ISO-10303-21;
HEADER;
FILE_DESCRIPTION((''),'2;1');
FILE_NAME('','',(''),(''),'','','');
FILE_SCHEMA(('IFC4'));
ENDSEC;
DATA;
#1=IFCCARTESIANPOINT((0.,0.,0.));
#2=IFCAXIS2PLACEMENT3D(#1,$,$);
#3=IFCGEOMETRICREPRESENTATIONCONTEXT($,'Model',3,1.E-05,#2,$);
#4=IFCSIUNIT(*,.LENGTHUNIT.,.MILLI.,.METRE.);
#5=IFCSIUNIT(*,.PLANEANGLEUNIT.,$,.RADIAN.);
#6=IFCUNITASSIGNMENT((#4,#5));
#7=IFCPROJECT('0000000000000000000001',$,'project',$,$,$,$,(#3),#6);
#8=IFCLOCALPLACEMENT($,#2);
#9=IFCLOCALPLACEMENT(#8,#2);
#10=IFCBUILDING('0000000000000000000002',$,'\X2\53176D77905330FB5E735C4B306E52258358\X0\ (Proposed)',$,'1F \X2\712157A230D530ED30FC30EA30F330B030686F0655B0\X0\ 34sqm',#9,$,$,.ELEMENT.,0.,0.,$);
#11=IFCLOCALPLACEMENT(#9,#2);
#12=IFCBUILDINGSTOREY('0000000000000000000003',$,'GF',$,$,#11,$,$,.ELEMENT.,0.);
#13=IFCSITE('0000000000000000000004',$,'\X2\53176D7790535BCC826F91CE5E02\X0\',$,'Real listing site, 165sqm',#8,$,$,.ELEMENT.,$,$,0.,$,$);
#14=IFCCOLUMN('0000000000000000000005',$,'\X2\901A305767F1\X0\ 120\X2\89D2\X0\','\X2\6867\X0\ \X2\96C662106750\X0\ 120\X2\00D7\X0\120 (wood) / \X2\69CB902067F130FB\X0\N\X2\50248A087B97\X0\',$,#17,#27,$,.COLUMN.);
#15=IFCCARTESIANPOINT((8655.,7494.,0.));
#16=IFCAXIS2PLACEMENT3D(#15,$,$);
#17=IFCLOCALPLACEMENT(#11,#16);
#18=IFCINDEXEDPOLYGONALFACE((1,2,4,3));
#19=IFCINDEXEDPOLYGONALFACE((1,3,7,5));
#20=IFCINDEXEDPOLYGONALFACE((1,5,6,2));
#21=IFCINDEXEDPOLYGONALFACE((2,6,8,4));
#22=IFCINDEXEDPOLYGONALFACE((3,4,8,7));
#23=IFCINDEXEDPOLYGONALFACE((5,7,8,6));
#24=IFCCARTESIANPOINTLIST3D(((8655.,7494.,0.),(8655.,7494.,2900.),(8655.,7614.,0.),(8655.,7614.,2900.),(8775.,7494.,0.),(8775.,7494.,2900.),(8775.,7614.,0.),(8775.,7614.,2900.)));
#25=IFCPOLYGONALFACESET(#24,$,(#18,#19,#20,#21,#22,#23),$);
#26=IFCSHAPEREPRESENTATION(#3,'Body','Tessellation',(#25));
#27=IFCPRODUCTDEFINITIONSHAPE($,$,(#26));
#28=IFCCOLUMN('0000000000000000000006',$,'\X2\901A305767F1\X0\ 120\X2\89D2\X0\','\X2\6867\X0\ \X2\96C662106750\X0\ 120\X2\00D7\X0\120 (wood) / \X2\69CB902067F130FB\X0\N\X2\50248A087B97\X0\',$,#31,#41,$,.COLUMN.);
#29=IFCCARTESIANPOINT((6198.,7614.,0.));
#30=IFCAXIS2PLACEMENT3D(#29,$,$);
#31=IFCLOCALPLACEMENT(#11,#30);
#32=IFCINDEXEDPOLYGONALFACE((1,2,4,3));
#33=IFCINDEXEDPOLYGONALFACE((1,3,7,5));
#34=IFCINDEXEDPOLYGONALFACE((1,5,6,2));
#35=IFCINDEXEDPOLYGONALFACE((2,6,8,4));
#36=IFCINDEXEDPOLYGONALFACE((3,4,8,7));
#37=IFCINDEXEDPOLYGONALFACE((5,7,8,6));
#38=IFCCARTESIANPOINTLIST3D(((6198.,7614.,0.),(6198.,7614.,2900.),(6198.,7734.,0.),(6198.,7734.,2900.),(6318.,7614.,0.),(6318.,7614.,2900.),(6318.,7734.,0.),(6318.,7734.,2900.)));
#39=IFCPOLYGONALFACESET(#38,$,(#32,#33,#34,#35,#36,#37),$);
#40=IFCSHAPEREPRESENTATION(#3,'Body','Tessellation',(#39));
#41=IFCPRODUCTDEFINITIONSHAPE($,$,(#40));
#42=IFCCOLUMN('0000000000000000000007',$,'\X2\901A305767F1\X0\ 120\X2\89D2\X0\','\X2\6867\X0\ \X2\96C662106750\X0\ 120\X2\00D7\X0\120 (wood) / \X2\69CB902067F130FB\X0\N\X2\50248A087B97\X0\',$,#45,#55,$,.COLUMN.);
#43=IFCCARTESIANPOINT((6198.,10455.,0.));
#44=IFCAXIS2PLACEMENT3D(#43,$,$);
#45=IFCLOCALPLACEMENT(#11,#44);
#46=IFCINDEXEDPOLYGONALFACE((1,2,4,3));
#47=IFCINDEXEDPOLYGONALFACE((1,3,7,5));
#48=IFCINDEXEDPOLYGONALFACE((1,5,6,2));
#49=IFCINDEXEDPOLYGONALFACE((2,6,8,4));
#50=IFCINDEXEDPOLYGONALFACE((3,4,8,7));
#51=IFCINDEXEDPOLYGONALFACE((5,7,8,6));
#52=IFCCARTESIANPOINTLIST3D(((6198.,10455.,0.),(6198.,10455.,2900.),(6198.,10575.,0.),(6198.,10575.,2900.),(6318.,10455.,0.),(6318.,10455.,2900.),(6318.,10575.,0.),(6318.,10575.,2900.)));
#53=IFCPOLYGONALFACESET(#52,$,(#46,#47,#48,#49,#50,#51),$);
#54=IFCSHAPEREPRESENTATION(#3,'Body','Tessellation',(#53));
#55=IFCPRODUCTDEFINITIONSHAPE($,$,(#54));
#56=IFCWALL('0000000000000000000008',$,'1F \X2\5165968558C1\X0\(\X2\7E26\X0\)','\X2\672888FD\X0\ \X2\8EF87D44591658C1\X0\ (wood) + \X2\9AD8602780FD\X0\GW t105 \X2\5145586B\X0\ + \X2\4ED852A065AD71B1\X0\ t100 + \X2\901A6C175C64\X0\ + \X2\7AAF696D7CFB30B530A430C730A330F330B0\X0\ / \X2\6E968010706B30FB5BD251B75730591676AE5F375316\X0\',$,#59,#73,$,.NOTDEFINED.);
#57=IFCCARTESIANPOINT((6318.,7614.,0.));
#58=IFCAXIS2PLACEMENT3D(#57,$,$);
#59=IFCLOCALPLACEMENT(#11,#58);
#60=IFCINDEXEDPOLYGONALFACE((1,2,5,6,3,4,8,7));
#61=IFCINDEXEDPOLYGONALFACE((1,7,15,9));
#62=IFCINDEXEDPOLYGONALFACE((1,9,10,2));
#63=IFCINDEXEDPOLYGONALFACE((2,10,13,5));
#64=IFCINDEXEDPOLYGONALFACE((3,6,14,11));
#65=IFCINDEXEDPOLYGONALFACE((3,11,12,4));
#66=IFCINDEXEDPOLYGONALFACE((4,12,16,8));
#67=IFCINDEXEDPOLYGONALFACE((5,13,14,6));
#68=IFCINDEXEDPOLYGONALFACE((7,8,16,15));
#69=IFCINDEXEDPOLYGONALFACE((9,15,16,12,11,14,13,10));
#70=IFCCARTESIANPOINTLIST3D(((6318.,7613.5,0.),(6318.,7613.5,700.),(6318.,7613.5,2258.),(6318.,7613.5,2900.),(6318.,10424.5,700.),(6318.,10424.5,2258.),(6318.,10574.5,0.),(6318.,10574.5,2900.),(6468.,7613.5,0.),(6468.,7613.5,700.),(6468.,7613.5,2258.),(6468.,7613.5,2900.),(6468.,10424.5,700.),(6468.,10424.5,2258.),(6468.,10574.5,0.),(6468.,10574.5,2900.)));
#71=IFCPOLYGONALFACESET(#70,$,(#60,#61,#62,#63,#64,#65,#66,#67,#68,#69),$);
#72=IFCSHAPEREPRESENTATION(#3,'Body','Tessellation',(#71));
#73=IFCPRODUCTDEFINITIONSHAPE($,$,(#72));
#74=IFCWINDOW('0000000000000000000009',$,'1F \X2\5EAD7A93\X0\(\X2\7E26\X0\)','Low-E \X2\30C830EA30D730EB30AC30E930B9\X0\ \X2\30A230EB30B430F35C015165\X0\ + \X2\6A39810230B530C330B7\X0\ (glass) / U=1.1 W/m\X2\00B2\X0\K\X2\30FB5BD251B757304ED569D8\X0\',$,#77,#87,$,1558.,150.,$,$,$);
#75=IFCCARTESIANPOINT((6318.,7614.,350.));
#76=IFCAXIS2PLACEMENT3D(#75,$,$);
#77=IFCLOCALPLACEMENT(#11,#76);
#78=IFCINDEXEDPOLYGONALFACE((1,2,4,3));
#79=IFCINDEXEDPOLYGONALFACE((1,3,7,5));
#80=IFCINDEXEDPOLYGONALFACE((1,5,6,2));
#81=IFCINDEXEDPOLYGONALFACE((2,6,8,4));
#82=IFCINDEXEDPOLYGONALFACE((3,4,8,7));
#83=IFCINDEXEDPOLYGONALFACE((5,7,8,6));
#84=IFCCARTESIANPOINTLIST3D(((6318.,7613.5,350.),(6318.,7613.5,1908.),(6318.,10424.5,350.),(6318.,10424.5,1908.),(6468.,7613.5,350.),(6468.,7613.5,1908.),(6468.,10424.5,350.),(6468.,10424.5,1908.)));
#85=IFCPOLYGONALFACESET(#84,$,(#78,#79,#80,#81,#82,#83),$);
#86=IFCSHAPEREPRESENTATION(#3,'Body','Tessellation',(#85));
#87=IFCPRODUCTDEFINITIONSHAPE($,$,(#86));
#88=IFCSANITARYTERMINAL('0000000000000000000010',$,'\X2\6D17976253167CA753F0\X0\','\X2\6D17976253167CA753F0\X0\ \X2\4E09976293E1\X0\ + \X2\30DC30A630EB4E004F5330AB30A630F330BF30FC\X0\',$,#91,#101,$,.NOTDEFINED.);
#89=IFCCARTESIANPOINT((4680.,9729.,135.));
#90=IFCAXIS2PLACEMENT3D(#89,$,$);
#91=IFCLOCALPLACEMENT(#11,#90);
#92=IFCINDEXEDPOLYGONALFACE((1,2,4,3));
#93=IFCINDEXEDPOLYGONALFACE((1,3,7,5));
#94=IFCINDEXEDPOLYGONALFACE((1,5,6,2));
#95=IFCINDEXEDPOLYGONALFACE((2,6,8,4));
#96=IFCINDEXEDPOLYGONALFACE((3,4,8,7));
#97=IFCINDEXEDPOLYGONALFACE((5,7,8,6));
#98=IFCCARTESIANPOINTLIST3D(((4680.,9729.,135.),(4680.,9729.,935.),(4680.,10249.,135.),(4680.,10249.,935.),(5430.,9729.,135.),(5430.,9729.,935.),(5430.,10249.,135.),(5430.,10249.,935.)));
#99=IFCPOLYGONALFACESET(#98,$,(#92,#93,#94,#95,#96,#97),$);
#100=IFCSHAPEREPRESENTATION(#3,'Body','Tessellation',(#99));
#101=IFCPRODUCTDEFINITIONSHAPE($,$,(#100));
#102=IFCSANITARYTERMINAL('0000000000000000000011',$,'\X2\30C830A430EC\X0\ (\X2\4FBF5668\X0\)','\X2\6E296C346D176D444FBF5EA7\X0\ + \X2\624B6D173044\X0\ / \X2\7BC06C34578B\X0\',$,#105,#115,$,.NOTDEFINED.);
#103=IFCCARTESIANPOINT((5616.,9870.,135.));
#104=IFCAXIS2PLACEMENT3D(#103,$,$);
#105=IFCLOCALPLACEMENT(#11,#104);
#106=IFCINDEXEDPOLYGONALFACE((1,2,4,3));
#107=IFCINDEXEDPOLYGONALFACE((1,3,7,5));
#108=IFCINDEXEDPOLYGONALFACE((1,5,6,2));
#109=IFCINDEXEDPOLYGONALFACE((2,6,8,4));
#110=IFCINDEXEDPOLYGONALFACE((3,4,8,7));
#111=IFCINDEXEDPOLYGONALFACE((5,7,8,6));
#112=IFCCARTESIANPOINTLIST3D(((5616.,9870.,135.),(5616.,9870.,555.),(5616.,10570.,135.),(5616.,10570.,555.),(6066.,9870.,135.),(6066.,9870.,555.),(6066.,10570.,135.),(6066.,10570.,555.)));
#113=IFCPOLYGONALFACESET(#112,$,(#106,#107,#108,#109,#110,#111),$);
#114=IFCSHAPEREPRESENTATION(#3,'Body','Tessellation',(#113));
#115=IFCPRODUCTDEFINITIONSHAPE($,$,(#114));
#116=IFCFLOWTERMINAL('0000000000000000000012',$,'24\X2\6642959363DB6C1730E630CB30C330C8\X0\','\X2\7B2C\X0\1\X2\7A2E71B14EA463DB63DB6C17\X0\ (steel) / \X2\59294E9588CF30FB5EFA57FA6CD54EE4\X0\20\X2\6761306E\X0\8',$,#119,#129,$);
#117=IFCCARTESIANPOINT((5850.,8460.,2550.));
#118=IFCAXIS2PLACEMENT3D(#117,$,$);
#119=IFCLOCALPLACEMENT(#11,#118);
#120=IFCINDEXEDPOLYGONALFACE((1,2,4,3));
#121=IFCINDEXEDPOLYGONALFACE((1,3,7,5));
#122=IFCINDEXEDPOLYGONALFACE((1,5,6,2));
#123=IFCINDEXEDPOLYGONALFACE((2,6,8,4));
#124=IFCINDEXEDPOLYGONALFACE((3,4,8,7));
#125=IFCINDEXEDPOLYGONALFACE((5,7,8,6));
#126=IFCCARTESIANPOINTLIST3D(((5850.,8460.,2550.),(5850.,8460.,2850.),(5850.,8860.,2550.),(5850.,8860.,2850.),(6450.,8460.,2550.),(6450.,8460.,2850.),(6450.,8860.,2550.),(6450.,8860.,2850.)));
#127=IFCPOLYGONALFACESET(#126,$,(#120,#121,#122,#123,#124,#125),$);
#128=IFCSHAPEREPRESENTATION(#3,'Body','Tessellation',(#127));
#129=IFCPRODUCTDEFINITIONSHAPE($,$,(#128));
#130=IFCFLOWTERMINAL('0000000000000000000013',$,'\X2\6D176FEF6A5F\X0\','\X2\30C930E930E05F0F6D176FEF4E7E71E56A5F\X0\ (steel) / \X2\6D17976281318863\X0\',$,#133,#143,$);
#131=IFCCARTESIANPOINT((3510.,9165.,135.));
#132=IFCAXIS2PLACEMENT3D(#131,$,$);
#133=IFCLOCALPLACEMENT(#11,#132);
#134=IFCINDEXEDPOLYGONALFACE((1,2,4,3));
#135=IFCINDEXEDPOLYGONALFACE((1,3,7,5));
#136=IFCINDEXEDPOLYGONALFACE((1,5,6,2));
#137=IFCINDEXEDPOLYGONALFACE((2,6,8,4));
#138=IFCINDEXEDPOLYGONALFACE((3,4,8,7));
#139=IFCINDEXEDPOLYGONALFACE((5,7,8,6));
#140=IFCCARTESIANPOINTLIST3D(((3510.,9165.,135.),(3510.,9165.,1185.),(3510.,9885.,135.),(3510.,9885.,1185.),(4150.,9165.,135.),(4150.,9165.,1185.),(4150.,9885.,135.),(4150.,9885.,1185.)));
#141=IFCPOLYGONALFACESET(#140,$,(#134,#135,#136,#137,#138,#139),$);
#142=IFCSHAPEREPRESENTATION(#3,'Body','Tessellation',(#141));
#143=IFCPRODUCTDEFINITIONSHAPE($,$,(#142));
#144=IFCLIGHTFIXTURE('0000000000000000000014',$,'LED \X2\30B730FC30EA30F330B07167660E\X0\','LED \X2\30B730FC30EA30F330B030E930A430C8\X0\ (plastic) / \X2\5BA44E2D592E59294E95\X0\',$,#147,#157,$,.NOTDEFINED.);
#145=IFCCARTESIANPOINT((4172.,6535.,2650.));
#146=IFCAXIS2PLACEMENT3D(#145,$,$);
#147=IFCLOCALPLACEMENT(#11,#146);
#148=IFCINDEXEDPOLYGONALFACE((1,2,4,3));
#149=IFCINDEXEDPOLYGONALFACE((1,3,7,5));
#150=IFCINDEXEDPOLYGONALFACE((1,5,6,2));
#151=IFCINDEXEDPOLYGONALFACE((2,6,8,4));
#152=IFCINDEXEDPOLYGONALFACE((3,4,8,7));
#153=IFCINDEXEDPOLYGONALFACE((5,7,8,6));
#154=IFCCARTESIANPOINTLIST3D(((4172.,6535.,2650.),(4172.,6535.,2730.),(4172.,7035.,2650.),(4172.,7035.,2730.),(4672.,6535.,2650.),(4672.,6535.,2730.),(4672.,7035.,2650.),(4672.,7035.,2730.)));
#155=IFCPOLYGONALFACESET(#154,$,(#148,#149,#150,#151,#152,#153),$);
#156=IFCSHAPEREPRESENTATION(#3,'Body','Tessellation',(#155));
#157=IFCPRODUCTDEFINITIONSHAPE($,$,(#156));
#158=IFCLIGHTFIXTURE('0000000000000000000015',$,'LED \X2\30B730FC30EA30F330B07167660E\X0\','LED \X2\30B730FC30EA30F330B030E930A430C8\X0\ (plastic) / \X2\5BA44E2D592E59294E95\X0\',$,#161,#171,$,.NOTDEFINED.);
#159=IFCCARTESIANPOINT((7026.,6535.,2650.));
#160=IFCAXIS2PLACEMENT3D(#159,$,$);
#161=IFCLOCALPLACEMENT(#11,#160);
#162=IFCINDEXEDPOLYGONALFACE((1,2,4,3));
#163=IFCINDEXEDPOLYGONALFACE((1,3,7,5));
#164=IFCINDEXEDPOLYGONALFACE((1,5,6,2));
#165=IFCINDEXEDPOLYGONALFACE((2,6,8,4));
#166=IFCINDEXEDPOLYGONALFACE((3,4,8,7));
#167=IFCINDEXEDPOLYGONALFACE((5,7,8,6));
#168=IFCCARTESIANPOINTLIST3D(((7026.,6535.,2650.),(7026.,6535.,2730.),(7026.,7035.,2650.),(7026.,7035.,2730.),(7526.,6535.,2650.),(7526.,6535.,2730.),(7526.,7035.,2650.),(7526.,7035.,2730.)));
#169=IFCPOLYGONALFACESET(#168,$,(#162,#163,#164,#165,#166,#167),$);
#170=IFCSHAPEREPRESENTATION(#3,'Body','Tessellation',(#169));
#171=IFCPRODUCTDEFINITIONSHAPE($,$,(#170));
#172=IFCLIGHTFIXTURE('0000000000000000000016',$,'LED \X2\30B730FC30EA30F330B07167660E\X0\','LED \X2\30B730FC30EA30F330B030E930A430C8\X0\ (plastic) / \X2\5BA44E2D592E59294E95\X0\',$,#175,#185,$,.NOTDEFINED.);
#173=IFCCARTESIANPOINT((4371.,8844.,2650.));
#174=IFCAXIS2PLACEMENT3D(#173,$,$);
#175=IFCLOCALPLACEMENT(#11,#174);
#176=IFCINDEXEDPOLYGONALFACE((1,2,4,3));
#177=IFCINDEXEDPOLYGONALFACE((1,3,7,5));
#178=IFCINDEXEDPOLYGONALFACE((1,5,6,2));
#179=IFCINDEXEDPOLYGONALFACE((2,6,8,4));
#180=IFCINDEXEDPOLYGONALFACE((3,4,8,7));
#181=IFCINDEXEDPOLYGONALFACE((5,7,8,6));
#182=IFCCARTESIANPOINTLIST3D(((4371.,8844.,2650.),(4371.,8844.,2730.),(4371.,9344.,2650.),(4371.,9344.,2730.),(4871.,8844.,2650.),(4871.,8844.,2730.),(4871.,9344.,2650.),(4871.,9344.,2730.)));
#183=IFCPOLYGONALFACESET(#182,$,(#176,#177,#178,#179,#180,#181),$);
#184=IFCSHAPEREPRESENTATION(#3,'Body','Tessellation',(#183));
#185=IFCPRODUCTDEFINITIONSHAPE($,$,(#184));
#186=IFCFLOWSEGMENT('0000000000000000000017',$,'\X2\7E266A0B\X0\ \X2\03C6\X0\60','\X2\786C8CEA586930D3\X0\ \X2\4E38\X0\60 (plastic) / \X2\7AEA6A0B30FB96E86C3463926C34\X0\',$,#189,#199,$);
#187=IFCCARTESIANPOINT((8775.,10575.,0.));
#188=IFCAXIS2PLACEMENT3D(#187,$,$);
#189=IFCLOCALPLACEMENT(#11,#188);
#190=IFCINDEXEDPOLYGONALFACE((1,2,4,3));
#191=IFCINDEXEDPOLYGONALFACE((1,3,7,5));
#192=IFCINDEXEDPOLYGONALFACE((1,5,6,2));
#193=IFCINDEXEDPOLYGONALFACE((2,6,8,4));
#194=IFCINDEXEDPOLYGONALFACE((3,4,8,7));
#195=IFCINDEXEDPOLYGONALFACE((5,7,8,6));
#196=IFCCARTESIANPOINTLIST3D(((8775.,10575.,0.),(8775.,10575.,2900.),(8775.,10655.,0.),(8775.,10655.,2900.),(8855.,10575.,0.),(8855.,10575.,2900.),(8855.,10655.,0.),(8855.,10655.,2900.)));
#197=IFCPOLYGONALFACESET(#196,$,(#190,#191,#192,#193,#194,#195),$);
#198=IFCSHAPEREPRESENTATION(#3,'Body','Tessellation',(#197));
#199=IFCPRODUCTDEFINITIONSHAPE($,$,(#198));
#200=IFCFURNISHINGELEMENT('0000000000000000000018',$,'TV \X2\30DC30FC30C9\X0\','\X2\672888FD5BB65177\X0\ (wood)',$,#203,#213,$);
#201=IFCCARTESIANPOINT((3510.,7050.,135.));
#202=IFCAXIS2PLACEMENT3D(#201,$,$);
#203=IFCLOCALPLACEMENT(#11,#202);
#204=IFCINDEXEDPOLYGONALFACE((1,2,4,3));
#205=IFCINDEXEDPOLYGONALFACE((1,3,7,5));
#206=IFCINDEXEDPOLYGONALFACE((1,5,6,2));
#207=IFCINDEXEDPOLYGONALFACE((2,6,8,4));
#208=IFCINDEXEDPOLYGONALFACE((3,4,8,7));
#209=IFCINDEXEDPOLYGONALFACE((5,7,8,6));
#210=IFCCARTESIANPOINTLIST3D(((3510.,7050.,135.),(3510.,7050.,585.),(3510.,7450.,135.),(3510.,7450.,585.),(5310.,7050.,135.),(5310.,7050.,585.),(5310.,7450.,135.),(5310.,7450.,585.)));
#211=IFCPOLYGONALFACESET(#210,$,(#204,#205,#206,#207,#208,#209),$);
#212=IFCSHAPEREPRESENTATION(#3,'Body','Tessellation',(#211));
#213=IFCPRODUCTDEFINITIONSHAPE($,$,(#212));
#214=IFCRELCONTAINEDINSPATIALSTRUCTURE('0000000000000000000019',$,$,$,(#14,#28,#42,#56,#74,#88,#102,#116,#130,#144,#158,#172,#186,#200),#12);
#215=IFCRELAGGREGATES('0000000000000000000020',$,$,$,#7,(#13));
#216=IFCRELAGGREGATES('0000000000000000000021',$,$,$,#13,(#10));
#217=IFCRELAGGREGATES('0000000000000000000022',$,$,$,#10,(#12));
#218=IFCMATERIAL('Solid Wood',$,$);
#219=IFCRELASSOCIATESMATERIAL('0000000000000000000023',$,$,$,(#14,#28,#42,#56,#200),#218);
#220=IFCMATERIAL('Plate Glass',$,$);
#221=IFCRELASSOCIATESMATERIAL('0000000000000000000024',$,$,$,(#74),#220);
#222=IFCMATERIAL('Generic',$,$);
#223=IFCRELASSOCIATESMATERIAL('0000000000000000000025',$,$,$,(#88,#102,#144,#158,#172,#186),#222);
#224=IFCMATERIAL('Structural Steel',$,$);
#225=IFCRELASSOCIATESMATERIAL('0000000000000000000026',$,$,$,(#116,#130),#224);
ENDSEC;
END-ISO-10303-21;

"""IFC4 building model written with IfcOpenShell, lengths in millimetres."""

from ifc_helpers import new_model, si_unit, frame, frame_2d, origin, place, context, project, spatial, rectangle, extrude, material, element, fill, save


model = new_model("IFC4")

# Units and contexts
model_context = context("Model", 3, precision=1e-05, world=origin())
ifc_project = project(units=[si_unit("LENGTHUNIT", "METRE", prefix="MILLI"), si_unit("PLANEANGLEUNIT", "RADIAN")], contexts=[model_context])

# Site, building, storey
site_placement = place(None, origin())
site = spatial("IfcSite", under=ifc_project, at=site_placement, Name="北海道富良野市", ObjectType="Real listing site, 165sqm", CompositionType="ELEMENT", RefElevation=0.0)
building_placement = place(site_placement, origin())
building = spatial("IfcBuilding", under=site, at=building_placement, Name="北海道・平屋の別荘 (Proposed)", ObjectType="1F 無垢フローリングと漆喰 34sqm", CompositionType="ELEMENT", ElevationOfRefHeight=0.0, ElevationOfTerrain=0.0)
storey_placement = place(building_placement, origin())
storey = spatial("IfcBuildingStorey", under=building, at=storey_placement, Name="GF", CompositionType="ELEMENT", Elevation=0.0)

# Columns
ifc_material_1 = material(Name="Solid Wood")
column_1_placement = place(storey_placement, frame((8655.0, 7494.0, 0.0)))
element("IfcColumn", 1, at=column_1_placement, inside=storey, material=ifc_material_1, Name="通し柱 120角", Description="桧 集成材 120×120 (wood) / 構造柱・N値計算", PredefinedType="COLUMN", context=model_context, shape_type="SweptSolid", body=[
    extrude(rectangle(XDim=120.0, YDim=120.0, at=frame_2d((60.0, 60.0))), frame((8655.0, 7494.0, 0.0)), (0.0, 0.0, 1.0), 2900.0),
])
column_2_placement = place(storey_placement, frame((6198.0, 7614.0, 0.0)))
element("IfcColumn", 2, at=column_2_placement, inside=storey, material=ifc_material_1, Name="通し柱 120角", Description="桧 集成材 120×120 (wood) / 構造柱・N値計算", PredefinedType="COLUMN", context=model_context, shape_type="SweptSolid", body=[
    extrude(rectangle(XDim=120.0, YDim=120.0, at=frame_2d((60.0, 60.0))), frame((6198.0, 7614.0, 0.0)), (0.0, 0.0, 1.0), 2900.0),
])
column_3_placement = place(storey_placement, frame((6198.0, 10455.0, 0.0)))
element("IfcColumn", 3, at=column_3_placement, inside=storey, material=ifc_material_1, Name="通し柱 120角", Description="桧 集成材 120×120 (wood) / 構造柱・N値計算", PredefinedType="COLUMN", context=model_context, shape_type="SweptSolid", body=[
    extrude(rectangle(XDim=120.0, YDim=120.0, at=frame_2d((60.0, 60.0))), frame((6198.0, 10455.0, 0.0)), (0.0, 0.0, 1.0), 2900.0),
])

# Wall, opening, window
wall_1_placement = place(storey_placement, frame((6318.0, 7614.0, 0.0)))
wall_1 = element("IfcWall", 4, at=wall_1_placement, inside=storey, material=ifc_material_1, Name="1F 入隅壁(縦)", Description="木製 軸組外壁 (wood) + 高性能GW t105 充填 + 付加断熱 t100 + 通気層 + 窯業系サイディング / 準耐火・寒冷地外皮強化", PredefinedType="NOTDEFINED", context=model_context, shape_type="SweptSolid", body=[
    extrude(rectangle(XDim=150.0, YDim=2961.0, at=frame_2d((75.0, 1480.0))), frame((6318.0, 7614.0, 0.0)), (0.0, 0.0, 1.0), 2900.0),
])
opening_placement = place(storey_placement, frame((6318.0, 7614.0, 350.0)))
opening = element("IfcOpeningElement", 5, at=opening_placement, cuts=wall_1, PredefinedType="NOTDEFINED", context=model_context, shape_type="SweptSolid", body=[
    extrude(rectangle(XDim=150.0, YDim=2811.0, at=frame_2d((75.0, 1405.0))), frame((6318.0, 7614.0, 350.0)), (0.0, 0.0, 1.0), 1558.0),
])
ifc_material_2 = material(Name="Plate Glass")
window_placement = place(storey_placement, frame((6318.0, 7614.0, 350.0)))
window = element("IfcWindow", 6, at=window_placement, inside=storey, material=ifc_material_2, Name="1F 庭窓(縦)", Description="Low-E トリプルガラス アルゴン封入 + 樹脂サッシ (glass) / U=1.1 W/m²K・寒冷地仕様", OverallHeight=1558.0, OverallWidth=150.0, context=model_context, shape_type="SweptSolid", body=[
    extrude(rectangle(XDim=150.0, YDim=2811.0, at=frame_2d((75.0, 1405.0))), frame((6318.0, 7614.0, 350.0)), (0.0, 0.0, 1.0), 1558.0),
])
fill(opening, window)

# Sanitary terminals
ifc_material_3 = material(Name="Generic")
sanitary_terminal_1_placement = place(storey_placement, frame((4680.0, 9729.0, 135.0)))
element("IfcSanitaryTerminal", 7, at=sanitary_terminal_1_placement, inside=storey, material=ifc_material_3, Name="洗面化粧台", Description="洗面化粧台 三面鏡 + ボウル一体カウンター", PredefinedType="NOTDEFINED", context=model_context, shape_type="SweptSolid", body=[
    extrude(rectangle(XDim=750.0, YDim=520.0, at=frame_2d((375.0, 260.0))), frame((4680.0, 9729.0, 135.0)), (0.0, 0.0, 1.0), 800.0),
])
sanitary_terminal_2_placement = place(storey_placement, frame((5616.0, 9870.0, 135.0)))
element("IfcSanitaryTerminal", 8, at=sanitary_terminal_2_placement, inside=storey, material=ifc_material_3, Name="トイレ (便器)", Description="温水洗浄便座 + 手洗い / 節水型", PredefinedType="NOTDEFINED", context=model_context, shape_type="SweptSolid", body=[
    extrude(rectangle(XDim=450.0, YDim=700.0, at=frame_2d((225.0, 350.0))), frame((5616.0, 9870.0, 135.0)), (0.0, 0.0, 1.0), 420.0),
])

# Flow terminals
ifc_material_4 = material(Name="Structural Steel")
flow_terminal_1_placement = place(storey_placement, frame((5850.0, 8460.0, 2550.0)))
element("IfcFlowTerminal", 9, at=flow_terminal_1_placement, inside=storey, material=ifc_material_4, Name="24時間換気ユニット", Description="第1種熱交換換気 (steel) / 天井裏・建基法令20条の8", context=model_context, shape_type="SweptSolid", body=[
    extrude(rectangle(XDim=600.0, YDim=400.0, at=frame_2d((300.0, 200.0))), frame((5850.0, 8460.0, 2550.0)), (0.0, 0.0, 1.0), 300.0),
])
flow_terminal_2_placement = place(storey_placement, frame((3510.0, 9165.0, 135.0)))
element("IfcFlowTerminal", 10, at=flow_terminal_2_placement, inside=storey, material=ifc_material_4, Name="洗濯機", Description="ドラム式洗濯乾燥機 (steel) / 洗面脱衣", context=model_context, shape_type="SweptSolid", body=[
    extrude(rectangle(XDim=640.0, YDim=720.0, at=frame_2d((320.0, 360.0))), frame((3510.0, 9165.0, 135.0)), (0.0, 0.0, 1.0), 1050.0),
])

# Light fixtures
light_fixture_1_placement = place(storey_placement, frame((4172.0, 6535.0, 2650.0)))
element("IfcLightFixture", 11, at=light_fixture_1_placement, inside=storey, material=ifc_material_3, Name="LED シーリング照明", Description="LED シーリングライト (plastic) / 室中央天井", PredefinedType="NOTDEFINED", context=model_context, shape_type="SweptSolid", body=[
    extrude(rectangle(XDim=500.0, YDim=500.0, at=frame_2d((250.0, 250.0))), frame((4172.0, 6535.0, 2650.0)), (0.0, 0.0, 1.0), 80.0),
])
light_fixture_2_placement = place(storey_placement, frame((7026.0, 6535.0, 2650.0)))
element("IfcLightFixture", 12, at=light_fixture_2_placement, inside=storey, material=ifc_material_3, Name="LED シーリング照明", Description="LED シーリングライト (plastic) / 室中央天井", PredefinedType="NOTDEFINED", context=model_context, shape_type="SweptSolid", body=[
    extrude(rectangle(XDim=500.0, YDim=500.0, at=frame_2d((250.0, 250.0))), frame((7026.0, 6535.0, 2650.0)), (0.0, 0.0, 1.0), 80.0),
])
light_fixture_3_placement = place(storey_placement, frame((4371.0, 8844.0, 2650.0)))
element("IfcLightFixture", 13, at=light_fixture_3_placement, inside=storey, material=ifc_material_3, Name="LED シーリング照明", Description="LED シーリングライト (plastic) / 室中央天井", PredefinedType="NOTDEFINED", context=model_context, shape_type="SweptSolid", body=[
    extrude(rectangle(XDim=500.0, YDim=500.0, at=frame_2d((250.0, 250.0))), frame((4371.0, 8844.0, 2650.0)), (0.0, 0.0, 1.0), 80.0),
])

# Flow segment
flow_segment_placement = place(storey_placement, frame((8775.0, 10575.0, 0.0)))
element("IfcFlowSegment", 14, at=flow_segment_placement, inside=storey, material=ifc_material_3, Name="縦樋 φ60", Description="硬質塩ビ 丸60 (plastic) / 竪樋・雨水排水", context=model_context, shape_type="SweptSolid", body=[
    extrude(rectangle(XDim=80.0, YDim=80.0, at=frame_2d((40.0, 40.0))), frame((8775.0, 10575.0, 0.0)), (0.0, 0.0, 1.0), 2900.0),
])

# Furnishing element
furnishing_placement = place(storey_placement, frame((3510.0, 7050.0, 135.0)))
element("IfcFurnishingElement", 15, at=furnishing_placement, inside=storey, material=ifc_material_1, Name="TV ボード", Description="木製家具 (wood)", context=model_context, shape_type="SweptSolid", body=[
    extrude(rectangle(XDim=1800.0, YDim=400.0, at=frame_2d((900.0, 200.0))), frame((3510.0, 7050.0, 135.0)), (0.0, 0.0, 1.0), 450.0),
])

save(model, "model.ifc")
